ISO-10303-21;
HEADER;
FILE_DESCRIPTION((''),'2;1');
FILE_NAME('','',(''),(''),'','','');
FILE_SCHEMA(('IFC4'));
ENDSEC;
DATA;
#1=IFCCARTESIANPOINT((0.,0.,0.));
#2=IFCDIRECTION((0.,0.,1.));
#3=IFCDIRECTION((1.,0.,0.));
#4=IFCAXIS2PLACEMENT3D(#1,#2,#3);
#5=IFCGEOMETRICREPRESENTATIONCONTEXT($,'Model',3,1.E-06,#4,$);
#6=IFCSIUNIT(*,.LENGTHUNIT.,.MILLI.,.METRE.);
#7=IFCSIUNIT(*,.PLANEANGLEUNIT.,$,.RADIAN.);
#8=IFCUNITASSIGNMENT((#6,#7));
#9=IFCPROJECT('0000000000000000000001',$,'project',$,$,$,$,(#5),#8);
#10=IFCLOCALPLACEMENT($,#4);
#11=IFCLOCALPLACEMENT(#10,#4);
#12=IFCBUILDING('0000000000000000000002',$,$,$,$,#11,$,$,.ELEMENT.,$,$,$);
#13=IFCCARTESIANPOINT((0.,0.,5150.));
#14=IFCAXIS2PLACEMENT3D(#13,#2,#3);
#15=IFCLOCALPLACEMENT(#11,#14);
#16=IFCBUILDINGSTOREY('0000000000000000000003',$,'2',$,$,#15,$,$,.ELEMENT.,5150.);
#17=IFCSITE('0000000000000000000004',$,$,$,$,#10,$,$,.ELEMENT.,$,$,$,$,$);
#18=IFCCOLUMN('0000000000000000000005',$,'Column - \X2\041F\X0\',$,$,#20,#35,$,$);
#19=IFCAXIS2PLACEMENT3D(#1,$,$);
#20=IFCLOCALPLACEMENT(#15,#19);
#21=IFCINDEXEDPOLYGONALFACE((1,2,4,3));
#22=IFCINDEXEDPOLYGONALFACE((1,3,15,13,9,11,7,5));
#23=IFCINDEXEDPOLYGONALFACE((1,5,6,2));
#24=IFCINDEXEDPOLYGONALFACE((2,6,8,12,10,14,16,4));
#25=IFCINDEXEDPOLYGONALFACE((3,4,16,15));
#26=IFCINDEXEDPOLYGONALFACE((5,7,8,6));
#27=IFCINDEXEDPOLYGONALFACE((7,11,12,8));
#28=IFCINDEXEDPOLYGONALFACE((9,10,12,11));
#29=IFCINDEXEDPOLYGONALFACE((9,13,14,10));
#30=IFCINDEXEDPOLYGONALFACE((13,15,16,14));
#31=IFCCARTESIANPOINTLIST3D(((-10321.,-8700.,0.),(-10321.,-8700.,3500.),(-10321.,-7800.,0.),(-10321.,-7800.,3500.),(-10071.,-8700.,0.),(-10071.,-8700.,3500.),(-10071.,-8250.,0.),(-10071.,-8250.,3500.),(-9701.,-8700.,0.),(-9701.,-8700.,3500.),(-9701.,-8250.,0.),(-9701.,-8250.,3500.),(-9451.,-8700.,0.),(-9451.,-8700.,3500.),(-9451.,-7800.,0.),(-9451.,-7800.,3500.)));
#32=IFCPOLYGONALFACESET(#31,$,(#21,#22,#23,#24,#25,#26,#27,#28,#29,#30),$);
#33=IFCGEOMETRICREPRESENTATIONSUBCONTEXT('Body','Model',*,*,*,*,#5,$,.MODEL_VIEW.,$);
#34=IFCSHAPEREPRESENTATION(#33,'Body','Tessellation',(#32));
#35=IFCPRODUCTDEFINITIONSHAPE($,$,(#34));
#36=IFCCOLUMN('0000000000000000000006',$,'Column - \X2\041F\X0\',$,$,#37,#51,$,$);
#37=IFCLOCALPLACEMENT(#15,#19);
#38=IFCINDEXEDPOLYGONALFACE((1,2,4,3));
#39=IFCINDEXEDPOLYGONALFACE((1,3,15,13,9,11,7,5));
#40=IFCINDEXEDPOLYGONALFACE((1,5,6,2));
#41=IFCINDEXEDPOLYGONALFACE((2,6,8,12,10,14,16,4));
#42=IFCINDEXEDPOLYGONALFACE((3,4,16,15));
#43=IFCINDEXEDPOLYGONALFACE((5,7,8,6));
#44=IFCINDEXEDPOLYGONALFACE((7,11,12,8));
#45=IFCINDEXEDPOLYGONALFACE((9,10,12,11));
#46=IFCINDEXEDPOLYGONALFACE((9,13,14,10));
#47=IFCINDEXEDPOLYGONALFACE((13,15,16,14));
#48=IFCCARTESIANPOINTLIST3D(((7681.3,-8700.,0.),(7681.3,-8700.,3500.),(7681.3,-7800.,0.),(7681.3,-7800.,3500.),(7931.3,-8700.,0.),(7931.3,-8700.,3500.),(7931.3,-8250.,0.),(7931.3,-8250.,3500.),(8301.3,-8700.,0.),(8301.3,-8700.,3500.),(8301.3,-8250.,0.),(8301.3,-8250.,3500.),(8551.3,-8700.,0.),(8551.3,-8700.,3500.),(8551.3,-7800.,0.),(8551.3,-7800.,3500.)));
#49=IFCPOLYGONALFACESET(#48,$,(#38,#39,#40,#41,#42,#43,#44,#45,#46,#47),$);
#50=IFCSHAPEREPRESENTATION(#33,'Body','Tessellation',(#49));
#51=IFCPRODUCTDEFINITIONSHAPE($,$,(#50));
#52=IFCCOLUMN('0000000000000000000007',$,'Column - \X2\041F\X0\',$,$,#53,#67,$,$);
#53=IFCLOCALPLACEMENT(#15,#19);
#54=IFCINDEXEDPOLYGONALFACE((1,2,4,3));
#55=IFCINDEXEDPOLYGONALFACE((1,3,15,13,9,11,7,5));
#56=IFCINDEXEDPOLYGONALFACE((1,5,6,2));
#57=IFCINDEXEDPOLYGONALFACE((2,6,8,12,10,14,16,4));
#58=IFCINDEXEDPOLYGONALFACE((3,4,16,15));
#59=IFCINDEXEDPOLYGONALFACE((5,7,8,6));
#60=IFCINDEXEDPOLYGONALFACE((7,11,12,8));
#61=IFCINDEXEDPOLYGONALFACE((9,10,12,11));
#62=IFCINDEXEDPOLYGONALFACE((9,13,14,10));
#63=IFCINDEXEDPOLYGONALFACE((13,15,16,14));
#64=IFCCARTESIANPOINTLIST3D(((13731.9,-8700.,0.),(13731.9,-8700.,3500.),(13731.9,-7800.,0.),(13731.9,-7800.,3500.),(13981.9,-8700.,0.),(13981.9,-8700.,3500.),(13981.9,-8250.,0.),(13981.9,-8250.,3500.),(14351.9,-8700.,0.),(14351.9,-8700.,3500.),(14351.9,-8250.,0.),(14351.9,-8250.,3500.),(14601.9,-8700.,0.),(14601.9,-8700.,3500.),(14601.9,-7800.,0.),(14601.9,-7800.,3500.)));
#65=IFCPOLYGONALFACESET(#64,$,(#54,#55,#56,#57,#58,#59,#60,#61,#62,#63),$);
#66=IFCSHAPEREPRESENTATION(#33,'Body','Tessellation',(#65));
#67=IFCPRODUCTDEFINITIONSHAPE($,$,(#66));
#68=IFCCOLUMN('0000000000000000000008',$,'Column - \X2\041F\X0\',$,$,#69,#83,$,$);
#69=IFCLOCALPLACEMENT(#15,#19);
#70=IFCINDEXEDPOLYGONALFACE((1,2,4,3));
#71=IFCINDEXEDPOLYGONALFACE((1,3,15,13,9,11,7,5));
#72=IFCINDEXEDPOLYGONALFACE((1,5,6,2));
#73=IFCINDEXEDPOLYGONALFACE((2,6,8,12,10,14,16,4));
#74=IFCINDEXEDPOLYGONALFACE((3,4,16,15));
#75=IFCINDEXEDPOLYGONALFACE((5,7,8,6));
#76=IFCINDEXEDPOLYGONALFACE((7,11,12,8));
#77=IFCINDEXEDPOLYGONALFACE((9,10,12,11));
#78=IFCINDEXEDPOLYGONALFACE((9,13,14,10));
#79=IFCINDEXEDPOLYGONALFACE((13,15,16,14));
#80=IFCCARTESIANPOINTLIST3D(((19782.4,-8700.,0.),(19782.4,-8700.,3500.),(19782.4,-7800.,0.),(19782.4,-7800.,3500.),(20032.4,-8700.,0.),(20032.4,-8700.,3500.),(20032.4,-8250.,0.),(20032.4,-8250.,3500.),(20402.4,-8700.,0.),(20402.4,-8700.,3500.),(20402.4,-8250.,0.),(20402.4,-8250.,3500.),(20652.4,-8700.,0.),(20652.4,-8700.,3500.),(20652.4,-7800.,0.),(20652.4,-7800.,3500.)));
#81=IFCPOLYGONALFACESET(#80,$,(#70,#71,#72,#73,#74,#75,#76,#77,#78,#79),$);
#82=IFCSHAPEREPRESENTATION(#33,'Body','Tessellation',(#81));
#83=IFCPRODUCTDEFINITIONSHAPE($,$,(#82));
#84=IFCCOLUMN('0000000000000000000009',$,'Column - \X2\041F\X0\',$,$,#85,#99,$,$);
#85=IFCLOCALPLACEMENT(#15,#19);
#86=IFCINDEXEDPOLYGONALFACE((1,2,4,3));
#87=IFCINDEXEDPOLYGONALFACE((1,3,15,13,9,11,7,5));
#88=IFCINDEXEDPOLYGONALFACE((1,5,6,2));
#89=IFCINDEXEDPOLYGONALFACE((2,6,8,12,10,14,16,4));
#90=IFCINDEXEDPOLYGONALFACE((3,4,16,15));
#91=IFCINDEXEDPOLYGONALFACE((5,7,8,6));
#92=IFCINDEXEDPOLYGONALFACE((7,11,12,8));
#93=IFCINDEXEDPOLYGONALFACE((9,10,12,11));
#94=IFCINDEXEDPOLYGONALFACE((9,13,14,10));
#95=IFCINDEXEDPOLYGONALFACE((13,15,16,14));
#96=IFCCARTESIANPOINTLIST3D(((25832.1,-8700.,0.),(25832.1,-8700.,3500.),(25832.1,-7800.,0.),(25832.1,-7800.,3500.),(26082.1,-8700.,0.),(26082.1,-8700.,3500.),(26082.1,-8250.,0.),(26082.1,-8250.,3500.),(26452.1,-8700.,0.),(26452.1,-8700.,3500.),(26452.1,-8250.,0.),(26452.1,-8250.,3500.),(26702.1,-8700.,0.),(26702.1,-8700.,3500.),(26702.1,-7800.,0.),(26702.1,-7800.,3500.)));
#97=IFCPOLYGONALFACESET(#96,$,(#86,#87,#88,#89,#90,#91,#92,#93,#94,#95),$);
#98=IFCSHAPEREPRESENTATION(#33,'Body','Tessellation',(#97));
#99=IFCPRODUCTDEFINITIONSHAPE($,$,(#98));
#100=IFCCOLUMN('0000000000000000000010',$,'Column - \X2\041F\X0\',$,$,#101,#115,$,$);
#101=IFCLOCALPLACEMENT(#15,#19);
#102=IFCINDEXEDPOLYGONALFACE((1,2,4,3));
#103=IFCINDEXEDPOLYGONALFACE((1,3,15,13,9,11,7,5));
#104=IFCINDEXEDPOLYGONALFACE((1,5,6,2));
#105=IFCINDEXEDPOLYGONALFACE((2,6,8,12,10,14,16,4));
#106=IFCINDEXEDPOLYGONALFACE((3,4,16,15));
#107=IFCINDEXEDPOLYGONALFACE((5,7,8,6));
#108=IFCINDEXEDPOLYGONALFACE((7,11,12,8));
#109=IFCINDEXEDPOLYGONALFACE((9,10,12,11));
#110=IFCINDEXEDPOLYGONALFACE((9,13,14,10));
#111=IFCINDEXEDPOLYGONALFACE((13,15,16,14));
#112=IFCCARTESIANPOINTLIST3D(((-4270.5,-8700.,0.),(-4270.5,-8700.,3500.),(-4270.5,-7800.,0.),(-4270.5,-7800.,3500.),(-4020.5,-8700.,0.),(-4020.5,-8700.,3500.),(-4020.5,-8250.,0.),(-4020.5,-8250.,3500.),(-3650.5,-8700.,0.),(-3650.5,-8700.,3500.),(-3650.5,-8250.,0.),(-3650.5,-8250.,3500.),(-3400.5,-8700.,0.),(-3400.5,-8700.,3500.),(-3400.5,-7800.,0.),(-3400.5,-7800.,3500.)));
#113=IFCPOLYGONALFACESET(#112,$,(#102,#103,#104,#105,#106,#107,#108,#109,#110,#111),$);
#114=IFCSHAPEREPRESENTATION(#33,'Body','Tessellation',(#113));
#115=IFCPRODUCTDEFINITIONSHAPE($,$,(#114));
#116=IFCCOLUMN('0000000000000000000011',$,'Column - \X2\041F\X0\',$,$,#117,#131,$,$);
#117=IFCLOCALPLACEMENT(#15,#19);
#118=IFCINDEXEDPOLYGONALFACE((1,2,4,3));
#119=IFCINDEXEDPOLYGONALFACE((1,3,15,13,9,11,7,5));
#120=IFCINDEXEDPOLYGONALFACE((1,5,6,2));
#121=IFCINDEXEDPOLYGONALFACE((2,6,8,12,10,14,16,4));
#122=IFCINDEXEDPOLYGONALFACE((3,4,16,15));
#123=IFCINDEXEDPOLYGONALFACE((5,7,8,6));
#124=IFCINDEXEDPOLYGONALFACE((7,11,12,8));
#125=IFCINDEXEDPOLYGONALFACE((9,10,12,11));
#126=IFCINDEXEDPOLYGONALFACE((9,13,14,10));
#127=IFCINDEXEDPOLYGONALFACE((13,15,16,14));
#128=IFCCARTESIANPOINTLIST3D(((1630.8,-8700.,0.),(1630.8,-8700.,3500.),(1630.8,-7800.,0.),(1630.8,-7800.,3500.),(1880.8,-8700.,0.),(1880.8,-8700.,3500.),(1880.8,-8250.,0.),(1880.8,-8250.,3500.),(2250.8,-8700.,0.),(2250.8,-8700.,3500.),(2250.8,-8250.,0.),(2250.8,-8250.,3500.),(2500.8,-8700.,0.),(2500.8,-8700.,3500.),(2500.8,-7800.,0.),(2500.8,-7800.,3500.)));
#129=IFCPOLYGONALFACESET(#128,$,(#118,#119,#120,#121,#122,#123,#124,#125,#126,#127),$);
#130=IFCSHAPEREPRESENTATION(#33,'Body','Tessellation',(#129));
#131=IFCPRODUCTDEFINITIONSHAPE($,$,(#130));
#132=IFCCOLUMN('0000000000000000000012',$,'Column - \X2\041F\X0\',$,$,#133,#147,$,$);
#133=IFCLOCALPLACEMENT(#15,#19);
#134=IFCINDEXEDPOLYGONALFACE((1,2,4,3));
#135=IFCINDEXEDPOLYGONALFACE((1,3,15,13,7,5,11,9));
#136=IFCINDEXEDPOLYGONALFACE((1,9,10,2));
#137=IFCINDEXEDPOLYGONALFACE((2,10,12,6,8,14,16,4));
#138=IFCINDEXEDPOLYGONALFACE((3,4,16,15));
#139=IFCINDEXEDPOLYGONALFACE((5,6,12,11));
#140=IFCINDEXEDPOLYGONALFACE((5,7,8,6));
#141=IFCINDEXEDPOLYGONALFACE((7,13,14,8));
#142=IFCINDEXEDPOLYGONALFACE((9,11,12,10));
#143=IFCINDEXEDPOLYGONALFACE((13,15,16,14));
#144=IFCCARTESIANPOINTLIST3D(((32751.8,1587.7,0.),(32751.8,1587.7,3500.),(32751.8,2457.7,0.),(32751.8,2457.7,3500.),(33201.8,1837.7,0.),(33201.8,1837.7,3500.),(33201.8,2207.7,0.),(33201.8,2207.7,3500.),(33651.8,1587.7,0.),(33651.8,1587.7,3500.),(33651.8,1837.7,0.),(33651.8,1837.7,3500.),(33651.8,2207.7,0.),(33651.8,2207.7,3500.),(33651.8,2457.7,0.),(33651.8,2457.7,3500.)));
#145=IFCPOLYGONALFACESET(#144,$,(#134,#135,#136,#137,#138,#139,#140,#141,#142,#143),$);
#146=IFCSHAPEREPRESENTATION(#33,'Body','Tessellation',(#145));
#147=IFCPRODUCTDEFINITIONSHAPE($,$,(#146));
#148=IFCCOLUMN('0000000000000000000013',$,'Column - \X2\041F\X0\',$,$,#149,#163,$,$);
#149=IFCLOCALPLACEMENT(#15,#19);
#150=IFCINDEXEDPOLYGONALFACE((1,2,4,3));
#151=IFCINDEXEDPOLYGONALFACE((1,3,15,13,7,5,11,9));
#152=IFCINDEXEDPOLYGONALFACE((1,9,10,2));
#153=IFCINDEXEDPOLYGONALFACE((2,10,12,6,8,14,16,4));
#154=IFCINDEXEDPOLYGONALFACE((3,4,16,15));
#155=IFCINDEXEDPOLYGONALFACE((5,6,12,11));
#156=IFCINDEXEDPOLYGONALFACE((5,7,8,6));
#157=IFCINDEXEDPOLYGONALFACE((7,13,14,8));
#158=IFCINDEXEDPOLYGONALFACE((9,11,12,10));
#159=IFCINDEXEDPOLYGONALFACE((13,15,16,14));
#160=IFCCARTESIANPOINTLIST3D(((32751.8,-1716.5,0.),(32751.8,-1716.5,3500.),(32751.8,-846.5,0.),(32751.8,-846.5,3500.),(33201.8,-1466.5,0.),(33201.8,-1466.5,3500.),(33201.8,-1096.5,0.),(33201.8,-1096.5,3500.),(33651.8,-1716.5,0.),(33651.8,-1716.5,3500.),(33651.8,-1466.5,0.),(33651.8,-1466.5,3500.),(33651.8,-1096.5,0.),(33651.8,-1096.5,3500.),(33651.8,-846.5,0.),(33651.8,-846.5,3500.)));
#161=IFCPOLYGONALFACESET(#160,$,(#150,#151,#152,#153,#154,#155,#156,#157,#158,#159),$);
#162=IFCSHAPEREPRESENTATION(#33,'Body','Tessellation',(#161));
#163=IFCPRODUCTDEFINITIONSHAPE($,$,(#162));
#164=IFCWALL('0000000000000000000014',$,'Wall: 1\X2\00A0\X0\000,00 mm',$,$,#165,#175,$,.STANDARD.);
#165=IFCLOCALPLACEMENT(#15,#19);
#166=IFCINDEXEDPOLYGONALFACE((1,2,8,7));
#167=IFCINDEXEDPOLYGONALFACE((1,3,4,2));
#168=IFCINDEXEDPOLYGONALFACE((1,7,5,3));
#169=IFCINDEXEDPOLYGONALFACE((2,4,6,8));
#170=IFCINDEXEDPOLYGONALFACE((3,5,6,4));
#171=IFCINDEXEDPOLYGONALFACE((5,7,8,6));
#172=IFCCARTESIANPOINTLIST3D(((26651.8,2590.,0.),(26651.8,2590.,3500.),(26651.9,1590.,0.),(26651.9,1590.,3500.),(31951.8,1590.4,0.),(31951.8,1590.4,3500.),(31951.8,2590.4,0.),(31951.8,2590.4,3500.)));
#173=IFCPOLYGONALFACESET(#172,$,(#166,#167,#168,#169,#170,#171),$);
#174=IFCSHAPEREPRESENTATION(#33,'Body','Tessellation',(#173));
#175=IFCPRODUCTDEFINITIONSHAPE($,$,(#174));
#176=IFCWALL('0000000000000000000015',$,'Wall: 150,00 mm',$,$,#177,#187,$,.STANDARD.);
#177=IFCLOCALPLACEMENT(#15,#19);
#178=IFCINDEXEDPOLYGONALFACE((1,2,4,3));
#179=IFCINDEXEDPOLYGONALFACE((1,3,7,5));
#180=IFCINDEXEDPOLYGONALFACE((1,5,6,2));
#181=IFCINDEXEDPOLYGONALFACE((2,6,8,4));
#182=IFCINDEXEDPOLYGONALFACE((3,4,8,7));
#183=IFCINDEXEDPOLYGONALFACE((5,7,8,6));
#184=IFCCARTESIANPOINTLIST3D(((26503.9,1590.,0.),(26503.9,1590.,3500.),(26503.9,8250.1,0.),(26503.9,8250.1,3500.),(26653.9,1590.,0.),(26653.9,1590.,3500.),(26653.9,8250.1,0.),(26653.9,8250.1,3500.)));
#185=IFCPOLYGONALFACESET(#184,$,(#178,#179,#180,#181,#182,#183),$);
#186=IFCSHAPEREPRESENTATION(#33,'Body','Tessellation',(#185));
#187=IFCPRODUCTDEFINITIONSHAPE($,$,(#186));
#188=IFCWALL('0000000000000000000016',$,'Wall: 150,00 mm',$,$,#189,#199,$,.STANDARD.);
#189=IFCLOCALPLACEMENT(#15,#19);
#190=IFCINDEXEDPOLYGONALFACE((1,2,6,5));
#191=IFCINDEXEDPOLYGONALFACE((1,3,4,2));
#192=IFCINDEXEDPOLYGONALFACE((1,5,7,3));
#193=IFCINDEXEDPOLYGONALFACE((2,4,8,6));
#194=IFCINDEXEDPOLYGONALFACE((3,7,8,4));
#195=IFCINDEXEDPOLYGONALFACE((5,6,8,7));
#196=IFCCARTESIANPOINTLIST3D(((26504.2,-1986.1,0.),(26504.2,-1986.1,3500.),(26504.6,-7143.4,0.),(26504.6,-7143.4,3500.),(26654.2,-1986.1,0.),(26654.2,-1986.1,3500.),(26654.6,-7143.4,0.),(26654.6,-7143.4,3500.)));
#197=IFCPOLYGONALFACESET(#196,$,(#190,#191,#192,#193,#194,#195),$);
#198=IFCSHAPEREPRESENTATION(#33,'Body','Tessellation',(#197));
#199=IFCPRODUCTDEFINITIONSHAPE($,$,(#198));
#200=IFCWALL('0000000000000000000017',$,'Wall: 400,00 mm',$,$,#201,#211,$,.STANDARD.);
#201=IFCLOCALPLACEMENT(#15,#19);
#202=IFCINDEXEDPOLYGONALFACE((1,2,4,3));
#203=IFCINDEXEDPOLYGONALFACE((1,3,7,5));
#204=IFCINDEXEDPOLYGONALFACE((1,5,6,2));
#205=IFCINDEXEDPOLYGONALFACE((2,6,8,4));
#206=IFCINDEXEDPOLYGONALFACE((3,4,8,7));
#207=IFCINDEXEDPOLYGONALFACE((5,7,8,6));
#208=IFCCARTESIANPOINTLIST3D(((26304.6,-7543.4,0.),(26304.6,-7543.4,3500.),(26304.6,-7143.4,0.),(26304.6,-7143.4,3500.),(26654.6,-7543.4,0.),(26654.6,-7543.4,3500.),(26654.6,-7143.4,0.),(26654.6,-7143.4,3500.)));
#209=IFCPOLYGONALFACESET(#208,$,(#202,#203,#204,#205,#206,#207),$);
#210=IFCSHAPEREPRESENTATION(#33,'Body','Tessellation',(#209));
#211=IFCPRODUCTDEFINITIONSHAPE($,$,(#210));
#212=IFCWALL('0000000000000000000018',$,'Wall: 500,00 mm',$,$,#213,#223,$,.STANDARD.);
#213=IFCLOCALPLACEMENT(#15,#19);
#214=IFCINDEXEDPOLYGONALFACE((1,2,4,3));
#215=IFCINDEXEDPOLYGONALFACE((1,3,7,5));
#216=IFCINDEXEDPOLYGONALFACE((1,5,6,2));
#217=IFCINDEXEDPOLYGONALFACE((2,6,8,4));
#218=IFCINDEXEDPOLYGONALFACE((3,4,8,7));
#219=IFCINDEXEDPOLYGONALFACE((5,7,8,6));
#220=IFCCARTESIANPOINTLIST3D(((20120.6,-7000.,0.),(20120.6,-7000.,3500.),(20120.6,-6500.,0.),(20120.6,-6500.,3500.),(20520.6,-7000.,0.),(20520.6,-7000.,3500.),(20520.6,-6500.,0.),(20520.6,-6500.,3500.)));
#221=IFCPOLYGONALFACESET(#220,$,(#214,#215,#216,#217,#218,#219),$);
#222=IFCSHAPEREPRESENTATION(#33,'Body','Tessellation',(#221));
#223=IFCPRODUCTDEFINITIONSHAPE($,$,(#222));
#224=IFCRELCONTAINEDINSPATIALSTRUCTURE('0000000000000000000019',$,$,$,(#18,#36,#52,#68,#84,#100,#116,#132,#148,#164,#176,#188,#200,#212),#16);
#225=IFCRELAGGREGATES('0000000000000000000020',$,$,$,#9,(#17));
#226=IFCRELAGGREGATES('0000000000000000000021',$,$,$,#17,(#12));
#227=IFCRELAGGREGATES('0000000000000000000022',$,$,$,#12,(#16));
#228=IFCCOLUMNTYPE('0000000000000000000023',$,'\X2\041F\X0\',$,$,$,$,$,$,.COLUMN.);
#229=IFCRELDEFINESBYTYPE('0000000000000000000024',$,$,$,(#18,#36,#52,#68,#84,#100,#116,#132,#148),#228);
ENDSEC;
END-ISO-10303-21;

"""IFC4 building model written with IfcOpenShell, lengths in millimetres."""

from ifc_helpers import new_model, si_unit, frame, origin_with_axes, place, context, subcontext, project, spatial, line, indexed_curve, outline, extrude, source, transform, mapped, type_object, element, save


model = new_model("IFC4")

# Units and contexts
model_context = context("Model", 3, precision=1e-06, world=origin_with_axes())
body_context = subcontext(model_context, "Body", "Model", "MODEL_VIEW")
ifc_project = project(units=[si_unit("LENGTHUNIT", "METRE", prefix="MILLI"), si_unit("PLANEANGLEUNIT", "RADIAN")], contexts=[model_context])

# Site, building, storey
site_placement = place(None, origin_with_axes())
site = spatial("IfcSite", under=ifc_project, at=site_placement, CompositionType="ELEMENT")
building_placement = place(site_placement, origin_with_axes())
building = spatial("IfcBuilding", under=site, at=building_placement, CompositionType="ELEMENT")
storey_placement = place(building_placement, frame((0.0, 0.0, 5150.0), z_axis=(0.0, 0.0, 1.0), x_axis=(1.0, 0.0, 0.0)))
storey = spatial("IfcBuildingStorey", under=building, at=storey_placement, Name="2", CompositionType="ELEMENT", Elevation=5150.0)

# Columns
column_type = type_object("IfcColumnType", Name="П", PredefinedType="COLUMN")
shared_shape_1 = source(origin_with_axes(), body_context, "Body", "SweptSolid", [
    extrude(outline(indexed_curve([(-450.0, -435.0), (450.0, -435.0), (450.0, -185.0), (0.0, -185.0), (0.0, 185.0), (450.0, 185.0), (450.0, 435.0), (-450.0, 435.0)], segments=[line(1, 2), line(2, 3), line(3, 4), line(4, 5), line(5, 6), line(6, 7), line(7, 8), line(8, 1)])), origin_with_axes(), (0.0, 0.0, 1.0), 3500.0),
])
for number, where, z_axis, x_axis, name in (
    (1, (-9886.0, -8250.0, 0.0), (0.0, 0.0, 1.0), (0.0, -1.0, 0.0), "Column - П"),
    (2, (8116.3, -8250.0, 0.0), (0.0, 0.0, 1.0), (0.0, -1.0, 0.0), "Column - П"),
    (3, (14166.9, -8250.0, 0.0), (0.0, 0.0, 1.0), (0.0, -1.0, 0.0), "Column - П"),
    (4, (20217.4, -8250.0, 0.0), (0.0, 0.0, 1.0), (0.0, -1.0, 0.0), "Column - П"),
    (5, (26267.1, -8250.0, 0.0), (0.0, 0.0, 1.0), (0.0, -1.0, 0.0), "Column - П"),
    (6, (-3835.5, -8250.0, 0.0), (0.0, 0.0, 1.0), (0.0, -1.0, 0.0), "Column - П"),
    (7, (2065.8, -8250.0, 0.0), (0.0, 0.0, 1.0), (0.0, -1.0, 0.0), "Column - П"),
    (8, (33201.8, 2022.7, 0.0), (0.0, 0.0, 1.0), (1.0, 0.0, 0.0), "Column - П"),
    (9, (33201.8, -1281.5, 0.0), (0.0, 0.0, 1.0), (1.0, 0.0, 0.0), "Column - П"),
):
    element("IfcColumn", number, at=place(storey_placement, frame(where, z_axis=z_axis, x_axis=x_axis)), inside=storey, type_object=column_type, Name=name, context=body_context, shape_type="MappedRepresentation", body=[
        mapped(shared_shape_1, transform((0.0, 0.0, 0.0), x_axis=(1.0, 0.0, 0.0), y_axis=(0.0, 1.0, 0.0), z_axis=(0.0, 0.0, 1.0), scale=1.0)),
    ])

# Walls
wall_1_placement = place(storey_placement, frame((31951.8, 1590.4, 0.0), z_axis=(0.0, 0.0, 1.0), x_axis=(-1.0, -0.000069, 0.0)))
element("IfcWall", 10, at=wall_1_placement, inside=storey, Name="Wall: 1 000,00 mm", PredefinedType="STANDARD", context=body_context, shape_type="SweptSolid", body=[
    extrude(outline(indexed_curve([(-0.1, -1000.0), (5299.9, -1000.0), (5299.9, 0.0), (0.0, 0.0)], segments=[line(1, 2), line(2, 3), line(3, 4), line(4, 1)])), origin_with_axes(), (0.0, 0.0, 1.0), 3500.0),
])
wall_2_placement = place(storey_placement, frame((26503.9, 1590.0, 0.0), z_axis=(0.0, 0.0, 1.0), x_axis=(0.0, 1.0, 0.0)))
element("IfcWall", 11, at=wall_2_placement, inside=storey, Name="Wall: 150,00 mm", PredefinedType="STANDARD", context=body_context, shape_type="SweptSolid", body=[
    extrude(outline(indexed_curve([(0.0, -150.0), (6660.1, -150.0), (6660.1, 0.0), (0.0, 0.0)], segments=[line(1, 2), line(2, 3), line(3, 4), line(4, 1)])), origin_with_axes(), (0.0, 0.0, 1.0), 3500.0),
])
wall_3_placement = place(storey_placement, frame((26504.2, -1986.1, 0.0), z_axis=(0.0, 0.0, 1.0), x_axis=(0.000069, -1.0, 0.0)))
element("IfcWall", 12, at=wall_3_placement, inside=storey, Name="Wall: 150,00 mm", PredefinedType="STANDARD", context=body_context, shape_type="SweptSolid", body=[
    extrude(outline(indexed_curve([(0.0, 0.0), (5157.2, 0.0), (5157.2, 150.0), (0.0, 150.0)], segments=[line(1, 2), line(2, 3), line(3, 4), line(4, 1)])), origin_with_axes(), (0.0, 0.0, 1.0), 3500.0),
])
wall_4_placement = place(storey_placement, frame((26654.6, -7143.4, 0.0), z_axis=(0.0, 0.0, 1.0), x_axis=(-1.0, -0.000069, 0.0)))
element("IfcWall", 13, at=wall_4_placement, inside=storey, Name="Wall: 400,00 mm", PredefinedType="STANDARD", context=body_context, shape_type="SweptSolid", body=[
    extrude(outline(indexed_curve([(0.0, 0.0), (350.0, 0.0), (350.0, 400.0), (0.0, 400.0)], segments=[line(1, 2), line(2, 3), line(3, 4), line(4, 1)])), origin_with_axes(), (0.0, 0.0, 1.0), 3500.0),
])
wall_5_placement = place(storey_placement, frame((20120.6, -7000.0, 0.0), z_axis=(0.0, 0.0, 1.0), x_axis=(1.0, 0.000069, 0.0)))
element("IfcWall", 14, at=wall_5_placement, inside=storey, Name="Wall: 500,00 mm", PredefinedType="STANDARD", context=body_context, shape_type="SweptSolid", body=[
    extrude(outline(indexed_curve([(0.0, 0.0), (400.0, 0.0), (400.0, 500.0), (0.0, 500.0)], segments=[line(1, 2), line(2, 3), line(3, 4), line(4, 1)])), origin_with_axes(), (0.0, 0.0, 1.0), 3500.0),
])

save(model, "model.ifc")
